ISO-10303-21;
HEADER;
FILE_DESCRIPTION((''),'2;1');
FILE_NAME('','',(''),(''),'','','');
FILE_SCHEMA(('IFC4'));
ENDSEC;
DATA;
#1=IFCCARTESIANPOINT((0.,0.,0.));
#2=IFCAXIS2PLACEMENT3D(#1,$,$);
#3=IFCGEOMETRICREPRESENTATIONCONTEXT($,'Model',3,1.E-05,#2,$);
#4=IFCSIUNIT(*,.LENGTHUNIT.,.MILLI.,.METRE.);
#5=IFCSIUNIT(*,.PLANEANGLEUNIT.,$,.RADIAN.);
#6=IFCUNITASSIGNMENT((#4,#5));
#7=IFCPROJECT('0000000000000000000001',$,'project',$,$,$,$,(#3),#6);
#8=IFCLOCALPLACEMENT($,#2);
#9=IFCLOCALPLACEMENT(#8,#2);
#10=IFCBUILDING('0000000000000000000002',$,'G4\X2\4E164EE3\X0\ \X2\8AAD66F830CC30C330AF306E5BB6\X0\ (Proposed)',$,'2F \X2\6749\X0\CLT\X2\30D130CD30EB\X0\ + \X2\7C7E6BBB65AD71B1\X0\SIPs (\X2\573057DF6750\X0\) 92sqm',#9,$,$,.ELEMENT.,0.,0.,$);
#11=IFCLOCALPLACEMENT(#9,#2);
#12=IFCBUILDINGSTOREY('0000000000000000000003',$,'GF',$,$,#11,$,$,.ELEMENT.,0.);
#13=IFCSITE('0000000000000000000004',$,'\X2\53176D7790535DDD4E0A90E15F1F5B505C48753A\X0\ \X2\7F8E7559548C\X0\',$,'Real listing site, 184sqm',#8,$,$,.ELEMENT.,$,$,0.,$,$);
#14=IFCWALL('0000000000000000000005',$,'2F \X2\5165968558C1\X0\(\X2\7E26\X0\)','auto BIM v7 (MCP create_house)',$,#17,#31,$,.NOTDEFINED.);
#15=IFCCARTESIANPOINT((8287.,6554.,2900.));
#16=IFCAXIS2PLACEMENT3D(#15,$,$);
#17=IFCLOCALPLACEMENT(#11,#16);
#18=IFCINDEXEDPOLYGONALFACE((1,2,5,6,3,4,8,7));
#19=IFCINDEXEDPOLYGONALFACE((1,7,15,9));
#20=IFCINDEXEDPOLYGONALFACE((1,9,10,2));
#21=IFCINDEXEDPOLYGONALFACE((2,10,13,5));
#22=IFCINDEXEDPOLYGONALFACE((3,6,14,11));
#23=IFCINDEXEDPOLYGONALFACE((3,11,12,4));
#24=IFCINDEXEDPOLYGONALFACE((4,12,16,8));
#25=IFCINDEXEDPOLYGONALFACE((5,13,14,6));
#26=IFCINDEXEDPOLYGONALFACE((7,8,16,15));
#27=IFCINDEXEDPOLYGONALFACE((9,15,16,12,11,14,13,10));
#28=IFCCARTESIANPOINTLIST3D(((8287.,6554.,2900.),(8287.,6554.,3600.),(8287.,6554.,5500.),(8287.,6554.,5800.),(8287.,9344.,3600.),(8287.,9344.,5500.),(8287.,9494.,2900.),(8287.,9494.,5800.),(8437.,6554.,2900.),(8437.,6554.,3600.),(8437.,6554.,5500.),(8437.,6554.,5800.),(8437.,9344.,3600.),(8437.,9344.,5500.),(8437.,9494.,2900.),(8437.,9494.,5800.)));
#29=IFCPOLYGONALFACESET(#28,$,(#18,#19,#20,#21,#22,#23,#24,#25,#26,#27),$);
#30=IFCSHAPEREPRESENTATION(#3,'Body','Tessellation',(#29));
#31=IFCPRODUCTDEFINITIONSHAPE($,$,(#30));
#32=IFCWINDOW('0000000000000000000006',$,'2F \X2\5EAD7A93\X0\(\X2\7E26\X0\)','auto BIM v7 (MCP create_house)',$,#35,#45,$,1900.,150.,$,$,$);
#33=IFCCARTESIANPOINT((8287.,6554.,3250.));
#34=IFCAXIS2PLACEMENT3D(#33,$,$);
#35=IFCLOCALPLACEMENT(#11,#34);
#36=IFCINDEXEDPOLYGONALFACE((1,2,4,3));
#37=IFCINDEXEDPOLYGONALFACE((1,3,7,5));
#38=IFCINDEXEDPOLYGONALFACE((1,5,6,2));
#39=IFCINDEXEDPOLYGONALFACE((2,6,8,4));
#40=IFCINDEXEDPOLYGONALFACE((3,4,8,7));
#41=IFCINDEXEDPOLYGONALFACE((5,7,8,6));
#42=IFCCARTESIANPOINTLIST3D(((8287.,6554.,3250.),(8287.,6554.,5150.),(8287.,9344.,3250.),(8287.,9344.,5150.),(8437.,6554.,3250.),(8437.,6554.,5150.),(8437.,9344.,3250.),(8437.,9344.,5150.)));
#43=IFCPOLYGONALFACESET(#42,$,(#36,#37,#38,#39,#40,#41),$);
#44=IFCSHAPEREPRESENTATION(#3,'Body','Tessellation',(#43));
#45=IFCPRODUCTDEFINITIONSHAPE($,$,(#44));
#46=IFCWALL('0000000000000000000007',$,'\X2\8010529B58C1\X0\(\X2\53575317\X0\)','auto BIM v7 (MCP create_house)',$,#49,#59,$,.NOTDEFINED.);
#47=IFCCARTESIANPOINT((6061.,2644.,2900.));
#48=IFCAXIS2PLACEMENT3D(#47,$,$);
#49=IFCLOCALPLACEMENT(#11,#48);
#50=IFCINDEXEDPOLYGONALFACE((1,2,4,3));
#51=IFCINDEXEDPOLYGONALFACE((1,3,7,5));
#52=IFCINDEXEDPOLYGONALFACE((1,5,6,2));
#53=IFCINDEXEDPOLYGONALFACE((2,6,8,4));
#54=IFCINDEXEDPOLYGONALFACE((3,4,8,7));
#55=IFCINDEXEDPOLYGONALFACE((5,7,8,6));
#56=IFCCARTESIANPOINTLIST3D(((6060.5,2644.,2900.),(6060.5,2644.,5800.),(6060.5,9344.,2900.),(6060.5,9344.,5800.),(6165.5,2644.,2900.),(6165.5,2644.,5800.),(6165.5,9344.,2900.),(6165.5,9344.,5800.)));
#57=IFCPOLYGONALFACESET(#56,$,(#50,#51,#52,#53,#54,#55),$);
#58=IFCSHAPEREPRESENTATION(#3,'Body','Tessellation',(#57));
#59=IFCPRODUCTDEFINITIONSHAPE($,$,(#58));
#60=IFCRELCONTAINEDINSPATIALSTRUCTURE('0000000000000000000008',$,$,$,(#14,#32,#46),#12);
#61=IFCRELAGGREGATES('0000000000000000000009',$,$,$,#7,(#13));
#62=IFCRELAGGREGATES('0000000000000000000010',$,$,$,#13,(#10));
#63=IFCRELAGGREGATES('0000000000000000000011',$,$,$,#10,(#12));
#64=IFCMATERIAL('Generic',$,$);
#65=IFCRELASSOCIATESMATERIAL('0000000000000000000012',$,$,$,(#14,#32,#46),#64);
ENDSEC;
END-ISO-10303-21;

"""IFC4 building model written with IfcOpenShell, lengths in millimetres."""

from ifc_helpers import new_model, si_unit, frame, frame_2d, origin, place, context, project, spatial, rectangle, extrude, material, element, fill, save


model = new_model("IFC4")

# Units and contexts
model_context = context("Model", 3, precision=1e-05, world=origin())
ifc_project = project(units=[si_unit("LENGTHUNIT", "METRE", prefix="MILLI"), si_unit("PLANEANGLEUNIT", "RADIAN")], contexts=[model_context])

# Site, building, storey
site_placement = place(None, origin())
site = spatial("IfcSite", under=ifc_project, at=site_placement, Name="北海道川上郡弟子屈町 美留和", ObjectType="Real listing site, 184sqm", CompositionType="ELEMENT", RefElevation=0.0)
building_placement = place(site_placement, origin())
building = spatial("IfcBuilding", under=site, at=building_placement, Name="G4世代 読書ヌックの家 (Proposed)", ObjectType="2F 杉CLTパネル + 籾殻断熱SIPs (地域材) 92sqm", CompositionType="ELEMENT", ElevationOfRefHeight=0.0, ElevationOfTerrain=0.0)
storey_placement = place(building_placement, origin())
storey = spatial("IfcBuildingStorey", under=building, at=storey_placement, Name="GF", CompositionType="ELEMENT", Elevation=0.0)

# Shared definitions
ifc_material = material(Name="Generic")

# Wall, opening, window
wall_1_placement = place(storey_placement, frame((8287.0, 6554.0, 2900.0)))
wall_1 = element("IfcWall", 1, at=wall_1_placement, inside=storey, material=ifc_material, Name="2F 入隅壁(縦)", Description="auto BIM v7 (MCP create_house)", PredefinedType="NOTDEFINED", context=model_context, shape_type="SweptSolid", body=[
    extrude(rectangle(XDim=150.0, YDim=2940.0, at=frame_2d((75.0, 1470.0))), frame((8287.0, 6554.0, 2900.0)), (0.0, 0.0, 1.0), 2900.0),
])
opening_1_placement = place(storey_placement, frame((8287.0, 6554.0, 3250.0)))
opening_1 = element("IfcOpeningElement", 2, at=opening_1_placement, cuts=wall_1, PredefinedType="NOTDEFINED", context=model_context, shape_type="SweptSolid", body=[
    extrude(rectangle(XDim=150.0, YDim=2790.0, at=frame_2d((75.0, 1395.0))), frame((8287.0, 6554.0, 3250.0)), (0.0, 0.0, 1.0), 1900.0),
])
window_1_placement = place(storey_placement, frame((8287.0, 6554.0, 3250.0)))
window_1 = element("IfcWindow", 3, at=window_1_placement, inside=storey, material=ifc_material, Name="2F 庭窓(縦)", Description="auto BIM v7 (MCP create_house)", OverallHeight=1900.0, OverallWidth=150.0, context=model_context, shape_type="SweptSolid", body=[
    extrude(rectangle(XDim=150.0, YDim=2790.0, at=frame_2d((75.0, 1395.0))), frame((8287.0, 6554.0, 3250.0)), (0.0, 0.0, 1.0), 1900.0),
])
fill(opening_1, window_1)

# Wall
wall_2_placement = place(storey_placement, frame((6061.0, 2644.0, 2900.0)))
element("IfcWall", 4, at=wall_2_placement, inside=storey, material=ifc_material, Name="耐力壁(南北)", Description="auto BIM v7 (MCP create_house)", PredefinedType="NOTDEFINED", context=model_context, shape_type="SweptSolid", body=[
    extrude(rectangle(XDim=105.0, YDim=6700.0, at=frame_2d((52.0, 3350.0))), frame((6061.0, 2644.0, 2900.0)), (0.0, 0.0, 1.0), 2900.0),
])

save(model, "model.ifc")
